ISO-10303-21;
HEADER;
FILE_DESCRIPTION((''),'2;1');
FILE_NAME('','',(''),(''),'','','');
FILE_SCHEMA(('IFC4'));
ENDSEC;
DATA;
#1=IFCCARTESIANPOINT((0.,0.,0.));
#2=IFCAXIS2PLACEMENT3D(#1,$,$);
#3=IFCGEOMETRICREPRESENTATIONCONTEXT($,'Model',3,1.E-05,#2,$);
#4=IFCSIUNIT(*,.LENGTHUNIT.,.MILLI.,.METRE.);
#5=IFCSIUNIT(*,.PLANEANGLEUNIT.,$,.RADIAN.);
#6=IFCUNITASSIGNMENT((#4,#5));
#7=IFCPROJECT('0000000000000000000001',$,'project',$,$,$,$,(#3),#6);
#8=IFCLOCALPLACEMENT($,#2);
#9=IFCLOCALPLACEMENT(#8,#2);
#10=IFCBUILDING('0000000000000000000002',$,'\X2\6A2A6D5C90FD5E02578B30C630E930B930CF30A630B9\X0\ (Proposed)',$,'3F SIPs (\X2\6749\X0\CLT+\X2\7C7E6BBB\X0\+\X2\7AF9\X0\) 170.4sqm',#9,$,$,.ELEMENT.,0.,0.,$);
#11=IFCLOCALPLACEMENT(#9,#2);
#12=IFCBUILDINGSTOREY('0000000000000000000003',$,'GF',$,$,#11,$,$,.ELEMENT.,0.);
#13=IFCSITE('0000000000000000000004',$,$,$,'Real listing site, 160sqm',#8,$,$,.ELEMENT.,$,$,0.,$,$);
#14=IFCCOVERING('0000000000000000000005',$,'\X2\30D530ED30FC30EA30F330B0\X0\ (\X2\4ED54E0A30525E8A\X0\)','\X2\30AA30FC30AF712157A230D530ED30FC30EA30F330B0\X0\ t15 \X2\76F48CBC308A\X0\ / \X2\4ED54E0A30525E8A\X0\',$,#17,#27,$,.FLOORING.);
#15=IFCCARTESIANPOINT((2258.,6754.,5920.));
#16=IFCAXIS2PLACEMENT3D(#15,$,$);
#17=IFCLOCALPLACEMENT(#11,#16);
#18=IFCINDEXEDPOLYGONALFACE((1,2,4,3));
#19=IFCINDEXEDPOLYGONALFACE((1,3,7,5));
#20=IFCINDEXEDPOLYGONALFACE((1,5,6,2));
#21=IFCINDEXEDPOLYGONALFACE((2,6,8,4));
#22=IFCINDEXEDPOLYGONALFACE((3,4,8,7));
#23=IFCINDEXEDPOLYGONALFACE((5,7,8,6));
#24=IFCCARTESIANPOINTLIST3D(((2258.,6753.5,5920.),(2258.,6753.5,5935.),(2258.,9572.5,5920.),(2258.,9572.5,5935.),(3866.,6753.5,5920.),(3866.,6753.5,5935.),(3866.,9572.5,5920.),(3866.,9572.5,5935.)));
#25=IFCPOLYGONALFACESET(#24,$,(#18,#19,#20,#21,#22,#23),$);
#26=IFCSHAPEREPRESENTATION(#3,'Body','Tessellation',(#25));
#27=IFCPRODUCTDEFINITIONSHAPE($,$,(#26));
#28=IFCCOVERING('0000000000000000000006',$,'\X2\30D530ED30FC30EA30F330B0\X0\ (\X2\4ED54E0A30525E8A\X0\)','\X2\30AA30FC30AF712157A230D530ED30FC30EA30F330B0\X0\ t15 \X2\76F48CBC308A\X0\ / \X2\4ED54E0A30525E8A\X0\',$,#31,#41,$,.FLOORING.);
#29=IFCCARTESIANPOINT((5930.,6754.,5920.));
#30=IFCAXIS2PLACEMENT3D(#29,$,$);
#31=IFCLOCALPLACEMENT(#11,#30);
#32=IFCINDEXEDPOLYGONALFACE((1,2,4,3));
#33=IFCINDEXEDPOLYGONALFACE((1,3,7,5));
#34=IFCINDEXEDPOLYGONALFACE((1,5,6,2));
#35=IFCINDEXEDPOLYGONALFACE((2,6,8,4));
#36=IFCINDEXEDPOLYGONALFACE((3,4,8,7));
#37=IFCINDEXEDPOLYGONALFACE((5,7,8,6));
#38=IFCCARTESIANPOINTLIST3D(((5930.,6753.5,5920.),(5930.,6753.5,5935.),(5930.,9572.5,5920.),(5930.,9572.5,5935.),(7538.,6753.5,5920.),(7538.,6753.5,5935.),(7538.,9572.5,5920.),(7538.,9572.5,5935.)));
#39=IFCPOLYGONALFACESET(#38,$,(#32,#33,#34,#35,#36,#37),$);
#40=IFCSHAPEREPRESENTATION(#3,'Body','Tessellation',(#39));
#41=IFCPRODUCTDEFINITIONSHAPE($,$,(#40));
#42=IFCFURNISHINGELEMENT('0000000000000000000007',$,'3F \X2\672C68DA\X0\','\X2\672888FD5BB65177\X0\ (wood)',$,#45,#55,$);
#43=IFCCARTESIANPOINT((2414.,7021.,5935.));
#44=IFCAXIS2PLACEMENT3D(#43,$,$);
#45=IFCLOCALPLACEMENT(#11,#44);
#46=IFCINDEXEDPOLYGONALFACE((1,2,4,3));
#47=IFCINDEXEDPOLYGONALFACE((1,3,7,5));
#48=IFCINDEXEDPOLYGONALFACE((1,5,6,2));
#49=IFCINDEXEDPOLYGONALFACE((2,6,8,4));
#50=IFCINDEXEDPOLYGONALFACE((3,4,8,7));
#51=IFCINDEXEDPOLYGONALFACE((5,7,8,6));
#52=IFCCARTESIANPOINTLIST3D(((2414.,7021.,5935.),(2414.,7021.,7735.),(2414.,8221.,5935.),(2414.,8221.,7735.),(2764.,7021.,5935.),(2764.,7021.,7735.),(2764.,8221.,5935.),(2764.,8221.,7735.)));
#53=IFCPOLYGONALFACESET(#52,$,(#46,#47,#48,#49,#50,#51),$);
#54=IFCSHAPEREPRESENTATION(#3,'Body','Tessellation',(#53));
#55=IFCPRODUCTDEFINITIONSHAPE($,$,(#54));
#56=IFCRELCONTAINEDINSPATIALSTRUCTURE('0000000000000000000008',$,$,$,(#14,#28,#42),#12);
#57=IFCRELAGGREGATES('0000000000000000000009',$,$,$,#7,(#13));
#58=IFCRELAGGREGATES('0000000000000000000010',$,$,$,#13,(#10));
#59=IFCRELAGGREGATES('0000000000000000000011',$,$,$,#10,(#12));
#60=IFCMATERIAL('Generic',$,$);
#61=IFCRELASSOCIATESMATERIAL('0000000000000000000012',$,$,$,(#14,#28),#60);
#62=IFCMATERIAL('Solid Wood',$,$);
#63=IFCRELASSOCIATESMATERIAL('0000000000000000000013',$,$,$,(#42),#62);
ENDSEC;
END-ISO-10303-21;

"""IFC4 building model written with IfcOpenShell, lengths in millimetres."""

from ifc_helpers import new_model, si_unit, frame, frame_2d, origin, place, context, project, spatial, rectangle, extrude, material, element, save


model = new_model("IFC4")

# Units and contexts
model_context = context("Model", 3, precision=1e-05, world=origin())
ifc_project = project(units=[si_unit("LENGTHUNIT", "METRE", prefix="MILLI"), si_unit("PLANEANGLEUNIT", "RADIAN")], contexts=[model_context])

# Site, building, storey
site_placement = place(None, origin())
site = spatial("IfcSite", under=ifc_project, at=site_placement, ObjectType="Real listing site, 160sqm", CompositionType="ELEMENT", RefElevation=0.0)
building_placement = place(site_placement, origin())
building = spatial("IfcBuilding", under=site, at=building_placement, Name="横浜都市型テラスハウス (Proposed)", ObjectType="3F SIPs (杉CLT+籾殻+竹) 170.4sqm", CompositionType="ELEMENT", ElevationOfRefHeight=0.0, ElevationOfTerrain=0.0)
storey_placement = place(building_placement, origin())
storey = spatial("IfcBuildingStorey", under=building, at=storey_placement, Name="GF", CompositionType="ELEMENT", Elevation=0.0)

# Shared definitions
ifc_material_1 = material(Name="Solid Wood")

# Shared definitions
ifc_material_2 = material(Name="Generic")

# Coverings
covering_1_placement = place(storey_placement, frame((2258.0, 6754.0, 5920.0)))
element("IfcCovering", 1, at=covering_1_placement, inside=storey, material=ifc_material_2, Name="フローリング (仕上げ床)", Description="オーク無垢フローリング t15 直貼り / 仕上げ床", PredefinedType="FLOORING", context=model_context, shape_type="SweptSolid", body=[
    extrude(rectangle(XDim=1608.0, YDim=2819.0, at=frame_2d((804.0, 1409.0))), frame((2258.0, 6754.0, 5920.0)), (0.0, 0.0, 1.0), 15.0),
])
covering_2_placement = place(storey_placement, frame((5930.0, 6754.0, 5920.0)))
element("IfcCovering", 2, at=covering_2_placement, inside=storey, material=ifc_material_2, Name="フローリング (仕上げ床)", Description="オーク無垢フローリング t15 直貼り / 仕上げ床", PredefinedType="FLOORING", context=model_context, shape_type="SweptSolid", body=[
    extrude(rectangle(XDim=1608.0, YDim=2819.0, at=frame_2d((804.0, 1409.0))), frame((5930.0, 6754.0, 5920.0)), (0.0, 0.0, 1.0), 15.0),
])

# Furnishing element
furnishing_placement = place(storey_placement, frame((2414.0, 7021.0, 5935.0)))
element("IfcFurnishingElement", 3, at=furnishing_placement, inside=storey, material=ifc_material_1, Name="3F 本棚", Description="木製家具 (wood)", context=model_context, shape_type="SweptSolid", body=[
    extrude(rectangle(XDim=350.0, YDim=1200.0, at=frame_2d((175.0, 600.0))), frame((2414.0, 7021.0, 5935.0)), (0.0, 0.0, 1.0), 1800.0),
])

save(model, "model.ifc")
